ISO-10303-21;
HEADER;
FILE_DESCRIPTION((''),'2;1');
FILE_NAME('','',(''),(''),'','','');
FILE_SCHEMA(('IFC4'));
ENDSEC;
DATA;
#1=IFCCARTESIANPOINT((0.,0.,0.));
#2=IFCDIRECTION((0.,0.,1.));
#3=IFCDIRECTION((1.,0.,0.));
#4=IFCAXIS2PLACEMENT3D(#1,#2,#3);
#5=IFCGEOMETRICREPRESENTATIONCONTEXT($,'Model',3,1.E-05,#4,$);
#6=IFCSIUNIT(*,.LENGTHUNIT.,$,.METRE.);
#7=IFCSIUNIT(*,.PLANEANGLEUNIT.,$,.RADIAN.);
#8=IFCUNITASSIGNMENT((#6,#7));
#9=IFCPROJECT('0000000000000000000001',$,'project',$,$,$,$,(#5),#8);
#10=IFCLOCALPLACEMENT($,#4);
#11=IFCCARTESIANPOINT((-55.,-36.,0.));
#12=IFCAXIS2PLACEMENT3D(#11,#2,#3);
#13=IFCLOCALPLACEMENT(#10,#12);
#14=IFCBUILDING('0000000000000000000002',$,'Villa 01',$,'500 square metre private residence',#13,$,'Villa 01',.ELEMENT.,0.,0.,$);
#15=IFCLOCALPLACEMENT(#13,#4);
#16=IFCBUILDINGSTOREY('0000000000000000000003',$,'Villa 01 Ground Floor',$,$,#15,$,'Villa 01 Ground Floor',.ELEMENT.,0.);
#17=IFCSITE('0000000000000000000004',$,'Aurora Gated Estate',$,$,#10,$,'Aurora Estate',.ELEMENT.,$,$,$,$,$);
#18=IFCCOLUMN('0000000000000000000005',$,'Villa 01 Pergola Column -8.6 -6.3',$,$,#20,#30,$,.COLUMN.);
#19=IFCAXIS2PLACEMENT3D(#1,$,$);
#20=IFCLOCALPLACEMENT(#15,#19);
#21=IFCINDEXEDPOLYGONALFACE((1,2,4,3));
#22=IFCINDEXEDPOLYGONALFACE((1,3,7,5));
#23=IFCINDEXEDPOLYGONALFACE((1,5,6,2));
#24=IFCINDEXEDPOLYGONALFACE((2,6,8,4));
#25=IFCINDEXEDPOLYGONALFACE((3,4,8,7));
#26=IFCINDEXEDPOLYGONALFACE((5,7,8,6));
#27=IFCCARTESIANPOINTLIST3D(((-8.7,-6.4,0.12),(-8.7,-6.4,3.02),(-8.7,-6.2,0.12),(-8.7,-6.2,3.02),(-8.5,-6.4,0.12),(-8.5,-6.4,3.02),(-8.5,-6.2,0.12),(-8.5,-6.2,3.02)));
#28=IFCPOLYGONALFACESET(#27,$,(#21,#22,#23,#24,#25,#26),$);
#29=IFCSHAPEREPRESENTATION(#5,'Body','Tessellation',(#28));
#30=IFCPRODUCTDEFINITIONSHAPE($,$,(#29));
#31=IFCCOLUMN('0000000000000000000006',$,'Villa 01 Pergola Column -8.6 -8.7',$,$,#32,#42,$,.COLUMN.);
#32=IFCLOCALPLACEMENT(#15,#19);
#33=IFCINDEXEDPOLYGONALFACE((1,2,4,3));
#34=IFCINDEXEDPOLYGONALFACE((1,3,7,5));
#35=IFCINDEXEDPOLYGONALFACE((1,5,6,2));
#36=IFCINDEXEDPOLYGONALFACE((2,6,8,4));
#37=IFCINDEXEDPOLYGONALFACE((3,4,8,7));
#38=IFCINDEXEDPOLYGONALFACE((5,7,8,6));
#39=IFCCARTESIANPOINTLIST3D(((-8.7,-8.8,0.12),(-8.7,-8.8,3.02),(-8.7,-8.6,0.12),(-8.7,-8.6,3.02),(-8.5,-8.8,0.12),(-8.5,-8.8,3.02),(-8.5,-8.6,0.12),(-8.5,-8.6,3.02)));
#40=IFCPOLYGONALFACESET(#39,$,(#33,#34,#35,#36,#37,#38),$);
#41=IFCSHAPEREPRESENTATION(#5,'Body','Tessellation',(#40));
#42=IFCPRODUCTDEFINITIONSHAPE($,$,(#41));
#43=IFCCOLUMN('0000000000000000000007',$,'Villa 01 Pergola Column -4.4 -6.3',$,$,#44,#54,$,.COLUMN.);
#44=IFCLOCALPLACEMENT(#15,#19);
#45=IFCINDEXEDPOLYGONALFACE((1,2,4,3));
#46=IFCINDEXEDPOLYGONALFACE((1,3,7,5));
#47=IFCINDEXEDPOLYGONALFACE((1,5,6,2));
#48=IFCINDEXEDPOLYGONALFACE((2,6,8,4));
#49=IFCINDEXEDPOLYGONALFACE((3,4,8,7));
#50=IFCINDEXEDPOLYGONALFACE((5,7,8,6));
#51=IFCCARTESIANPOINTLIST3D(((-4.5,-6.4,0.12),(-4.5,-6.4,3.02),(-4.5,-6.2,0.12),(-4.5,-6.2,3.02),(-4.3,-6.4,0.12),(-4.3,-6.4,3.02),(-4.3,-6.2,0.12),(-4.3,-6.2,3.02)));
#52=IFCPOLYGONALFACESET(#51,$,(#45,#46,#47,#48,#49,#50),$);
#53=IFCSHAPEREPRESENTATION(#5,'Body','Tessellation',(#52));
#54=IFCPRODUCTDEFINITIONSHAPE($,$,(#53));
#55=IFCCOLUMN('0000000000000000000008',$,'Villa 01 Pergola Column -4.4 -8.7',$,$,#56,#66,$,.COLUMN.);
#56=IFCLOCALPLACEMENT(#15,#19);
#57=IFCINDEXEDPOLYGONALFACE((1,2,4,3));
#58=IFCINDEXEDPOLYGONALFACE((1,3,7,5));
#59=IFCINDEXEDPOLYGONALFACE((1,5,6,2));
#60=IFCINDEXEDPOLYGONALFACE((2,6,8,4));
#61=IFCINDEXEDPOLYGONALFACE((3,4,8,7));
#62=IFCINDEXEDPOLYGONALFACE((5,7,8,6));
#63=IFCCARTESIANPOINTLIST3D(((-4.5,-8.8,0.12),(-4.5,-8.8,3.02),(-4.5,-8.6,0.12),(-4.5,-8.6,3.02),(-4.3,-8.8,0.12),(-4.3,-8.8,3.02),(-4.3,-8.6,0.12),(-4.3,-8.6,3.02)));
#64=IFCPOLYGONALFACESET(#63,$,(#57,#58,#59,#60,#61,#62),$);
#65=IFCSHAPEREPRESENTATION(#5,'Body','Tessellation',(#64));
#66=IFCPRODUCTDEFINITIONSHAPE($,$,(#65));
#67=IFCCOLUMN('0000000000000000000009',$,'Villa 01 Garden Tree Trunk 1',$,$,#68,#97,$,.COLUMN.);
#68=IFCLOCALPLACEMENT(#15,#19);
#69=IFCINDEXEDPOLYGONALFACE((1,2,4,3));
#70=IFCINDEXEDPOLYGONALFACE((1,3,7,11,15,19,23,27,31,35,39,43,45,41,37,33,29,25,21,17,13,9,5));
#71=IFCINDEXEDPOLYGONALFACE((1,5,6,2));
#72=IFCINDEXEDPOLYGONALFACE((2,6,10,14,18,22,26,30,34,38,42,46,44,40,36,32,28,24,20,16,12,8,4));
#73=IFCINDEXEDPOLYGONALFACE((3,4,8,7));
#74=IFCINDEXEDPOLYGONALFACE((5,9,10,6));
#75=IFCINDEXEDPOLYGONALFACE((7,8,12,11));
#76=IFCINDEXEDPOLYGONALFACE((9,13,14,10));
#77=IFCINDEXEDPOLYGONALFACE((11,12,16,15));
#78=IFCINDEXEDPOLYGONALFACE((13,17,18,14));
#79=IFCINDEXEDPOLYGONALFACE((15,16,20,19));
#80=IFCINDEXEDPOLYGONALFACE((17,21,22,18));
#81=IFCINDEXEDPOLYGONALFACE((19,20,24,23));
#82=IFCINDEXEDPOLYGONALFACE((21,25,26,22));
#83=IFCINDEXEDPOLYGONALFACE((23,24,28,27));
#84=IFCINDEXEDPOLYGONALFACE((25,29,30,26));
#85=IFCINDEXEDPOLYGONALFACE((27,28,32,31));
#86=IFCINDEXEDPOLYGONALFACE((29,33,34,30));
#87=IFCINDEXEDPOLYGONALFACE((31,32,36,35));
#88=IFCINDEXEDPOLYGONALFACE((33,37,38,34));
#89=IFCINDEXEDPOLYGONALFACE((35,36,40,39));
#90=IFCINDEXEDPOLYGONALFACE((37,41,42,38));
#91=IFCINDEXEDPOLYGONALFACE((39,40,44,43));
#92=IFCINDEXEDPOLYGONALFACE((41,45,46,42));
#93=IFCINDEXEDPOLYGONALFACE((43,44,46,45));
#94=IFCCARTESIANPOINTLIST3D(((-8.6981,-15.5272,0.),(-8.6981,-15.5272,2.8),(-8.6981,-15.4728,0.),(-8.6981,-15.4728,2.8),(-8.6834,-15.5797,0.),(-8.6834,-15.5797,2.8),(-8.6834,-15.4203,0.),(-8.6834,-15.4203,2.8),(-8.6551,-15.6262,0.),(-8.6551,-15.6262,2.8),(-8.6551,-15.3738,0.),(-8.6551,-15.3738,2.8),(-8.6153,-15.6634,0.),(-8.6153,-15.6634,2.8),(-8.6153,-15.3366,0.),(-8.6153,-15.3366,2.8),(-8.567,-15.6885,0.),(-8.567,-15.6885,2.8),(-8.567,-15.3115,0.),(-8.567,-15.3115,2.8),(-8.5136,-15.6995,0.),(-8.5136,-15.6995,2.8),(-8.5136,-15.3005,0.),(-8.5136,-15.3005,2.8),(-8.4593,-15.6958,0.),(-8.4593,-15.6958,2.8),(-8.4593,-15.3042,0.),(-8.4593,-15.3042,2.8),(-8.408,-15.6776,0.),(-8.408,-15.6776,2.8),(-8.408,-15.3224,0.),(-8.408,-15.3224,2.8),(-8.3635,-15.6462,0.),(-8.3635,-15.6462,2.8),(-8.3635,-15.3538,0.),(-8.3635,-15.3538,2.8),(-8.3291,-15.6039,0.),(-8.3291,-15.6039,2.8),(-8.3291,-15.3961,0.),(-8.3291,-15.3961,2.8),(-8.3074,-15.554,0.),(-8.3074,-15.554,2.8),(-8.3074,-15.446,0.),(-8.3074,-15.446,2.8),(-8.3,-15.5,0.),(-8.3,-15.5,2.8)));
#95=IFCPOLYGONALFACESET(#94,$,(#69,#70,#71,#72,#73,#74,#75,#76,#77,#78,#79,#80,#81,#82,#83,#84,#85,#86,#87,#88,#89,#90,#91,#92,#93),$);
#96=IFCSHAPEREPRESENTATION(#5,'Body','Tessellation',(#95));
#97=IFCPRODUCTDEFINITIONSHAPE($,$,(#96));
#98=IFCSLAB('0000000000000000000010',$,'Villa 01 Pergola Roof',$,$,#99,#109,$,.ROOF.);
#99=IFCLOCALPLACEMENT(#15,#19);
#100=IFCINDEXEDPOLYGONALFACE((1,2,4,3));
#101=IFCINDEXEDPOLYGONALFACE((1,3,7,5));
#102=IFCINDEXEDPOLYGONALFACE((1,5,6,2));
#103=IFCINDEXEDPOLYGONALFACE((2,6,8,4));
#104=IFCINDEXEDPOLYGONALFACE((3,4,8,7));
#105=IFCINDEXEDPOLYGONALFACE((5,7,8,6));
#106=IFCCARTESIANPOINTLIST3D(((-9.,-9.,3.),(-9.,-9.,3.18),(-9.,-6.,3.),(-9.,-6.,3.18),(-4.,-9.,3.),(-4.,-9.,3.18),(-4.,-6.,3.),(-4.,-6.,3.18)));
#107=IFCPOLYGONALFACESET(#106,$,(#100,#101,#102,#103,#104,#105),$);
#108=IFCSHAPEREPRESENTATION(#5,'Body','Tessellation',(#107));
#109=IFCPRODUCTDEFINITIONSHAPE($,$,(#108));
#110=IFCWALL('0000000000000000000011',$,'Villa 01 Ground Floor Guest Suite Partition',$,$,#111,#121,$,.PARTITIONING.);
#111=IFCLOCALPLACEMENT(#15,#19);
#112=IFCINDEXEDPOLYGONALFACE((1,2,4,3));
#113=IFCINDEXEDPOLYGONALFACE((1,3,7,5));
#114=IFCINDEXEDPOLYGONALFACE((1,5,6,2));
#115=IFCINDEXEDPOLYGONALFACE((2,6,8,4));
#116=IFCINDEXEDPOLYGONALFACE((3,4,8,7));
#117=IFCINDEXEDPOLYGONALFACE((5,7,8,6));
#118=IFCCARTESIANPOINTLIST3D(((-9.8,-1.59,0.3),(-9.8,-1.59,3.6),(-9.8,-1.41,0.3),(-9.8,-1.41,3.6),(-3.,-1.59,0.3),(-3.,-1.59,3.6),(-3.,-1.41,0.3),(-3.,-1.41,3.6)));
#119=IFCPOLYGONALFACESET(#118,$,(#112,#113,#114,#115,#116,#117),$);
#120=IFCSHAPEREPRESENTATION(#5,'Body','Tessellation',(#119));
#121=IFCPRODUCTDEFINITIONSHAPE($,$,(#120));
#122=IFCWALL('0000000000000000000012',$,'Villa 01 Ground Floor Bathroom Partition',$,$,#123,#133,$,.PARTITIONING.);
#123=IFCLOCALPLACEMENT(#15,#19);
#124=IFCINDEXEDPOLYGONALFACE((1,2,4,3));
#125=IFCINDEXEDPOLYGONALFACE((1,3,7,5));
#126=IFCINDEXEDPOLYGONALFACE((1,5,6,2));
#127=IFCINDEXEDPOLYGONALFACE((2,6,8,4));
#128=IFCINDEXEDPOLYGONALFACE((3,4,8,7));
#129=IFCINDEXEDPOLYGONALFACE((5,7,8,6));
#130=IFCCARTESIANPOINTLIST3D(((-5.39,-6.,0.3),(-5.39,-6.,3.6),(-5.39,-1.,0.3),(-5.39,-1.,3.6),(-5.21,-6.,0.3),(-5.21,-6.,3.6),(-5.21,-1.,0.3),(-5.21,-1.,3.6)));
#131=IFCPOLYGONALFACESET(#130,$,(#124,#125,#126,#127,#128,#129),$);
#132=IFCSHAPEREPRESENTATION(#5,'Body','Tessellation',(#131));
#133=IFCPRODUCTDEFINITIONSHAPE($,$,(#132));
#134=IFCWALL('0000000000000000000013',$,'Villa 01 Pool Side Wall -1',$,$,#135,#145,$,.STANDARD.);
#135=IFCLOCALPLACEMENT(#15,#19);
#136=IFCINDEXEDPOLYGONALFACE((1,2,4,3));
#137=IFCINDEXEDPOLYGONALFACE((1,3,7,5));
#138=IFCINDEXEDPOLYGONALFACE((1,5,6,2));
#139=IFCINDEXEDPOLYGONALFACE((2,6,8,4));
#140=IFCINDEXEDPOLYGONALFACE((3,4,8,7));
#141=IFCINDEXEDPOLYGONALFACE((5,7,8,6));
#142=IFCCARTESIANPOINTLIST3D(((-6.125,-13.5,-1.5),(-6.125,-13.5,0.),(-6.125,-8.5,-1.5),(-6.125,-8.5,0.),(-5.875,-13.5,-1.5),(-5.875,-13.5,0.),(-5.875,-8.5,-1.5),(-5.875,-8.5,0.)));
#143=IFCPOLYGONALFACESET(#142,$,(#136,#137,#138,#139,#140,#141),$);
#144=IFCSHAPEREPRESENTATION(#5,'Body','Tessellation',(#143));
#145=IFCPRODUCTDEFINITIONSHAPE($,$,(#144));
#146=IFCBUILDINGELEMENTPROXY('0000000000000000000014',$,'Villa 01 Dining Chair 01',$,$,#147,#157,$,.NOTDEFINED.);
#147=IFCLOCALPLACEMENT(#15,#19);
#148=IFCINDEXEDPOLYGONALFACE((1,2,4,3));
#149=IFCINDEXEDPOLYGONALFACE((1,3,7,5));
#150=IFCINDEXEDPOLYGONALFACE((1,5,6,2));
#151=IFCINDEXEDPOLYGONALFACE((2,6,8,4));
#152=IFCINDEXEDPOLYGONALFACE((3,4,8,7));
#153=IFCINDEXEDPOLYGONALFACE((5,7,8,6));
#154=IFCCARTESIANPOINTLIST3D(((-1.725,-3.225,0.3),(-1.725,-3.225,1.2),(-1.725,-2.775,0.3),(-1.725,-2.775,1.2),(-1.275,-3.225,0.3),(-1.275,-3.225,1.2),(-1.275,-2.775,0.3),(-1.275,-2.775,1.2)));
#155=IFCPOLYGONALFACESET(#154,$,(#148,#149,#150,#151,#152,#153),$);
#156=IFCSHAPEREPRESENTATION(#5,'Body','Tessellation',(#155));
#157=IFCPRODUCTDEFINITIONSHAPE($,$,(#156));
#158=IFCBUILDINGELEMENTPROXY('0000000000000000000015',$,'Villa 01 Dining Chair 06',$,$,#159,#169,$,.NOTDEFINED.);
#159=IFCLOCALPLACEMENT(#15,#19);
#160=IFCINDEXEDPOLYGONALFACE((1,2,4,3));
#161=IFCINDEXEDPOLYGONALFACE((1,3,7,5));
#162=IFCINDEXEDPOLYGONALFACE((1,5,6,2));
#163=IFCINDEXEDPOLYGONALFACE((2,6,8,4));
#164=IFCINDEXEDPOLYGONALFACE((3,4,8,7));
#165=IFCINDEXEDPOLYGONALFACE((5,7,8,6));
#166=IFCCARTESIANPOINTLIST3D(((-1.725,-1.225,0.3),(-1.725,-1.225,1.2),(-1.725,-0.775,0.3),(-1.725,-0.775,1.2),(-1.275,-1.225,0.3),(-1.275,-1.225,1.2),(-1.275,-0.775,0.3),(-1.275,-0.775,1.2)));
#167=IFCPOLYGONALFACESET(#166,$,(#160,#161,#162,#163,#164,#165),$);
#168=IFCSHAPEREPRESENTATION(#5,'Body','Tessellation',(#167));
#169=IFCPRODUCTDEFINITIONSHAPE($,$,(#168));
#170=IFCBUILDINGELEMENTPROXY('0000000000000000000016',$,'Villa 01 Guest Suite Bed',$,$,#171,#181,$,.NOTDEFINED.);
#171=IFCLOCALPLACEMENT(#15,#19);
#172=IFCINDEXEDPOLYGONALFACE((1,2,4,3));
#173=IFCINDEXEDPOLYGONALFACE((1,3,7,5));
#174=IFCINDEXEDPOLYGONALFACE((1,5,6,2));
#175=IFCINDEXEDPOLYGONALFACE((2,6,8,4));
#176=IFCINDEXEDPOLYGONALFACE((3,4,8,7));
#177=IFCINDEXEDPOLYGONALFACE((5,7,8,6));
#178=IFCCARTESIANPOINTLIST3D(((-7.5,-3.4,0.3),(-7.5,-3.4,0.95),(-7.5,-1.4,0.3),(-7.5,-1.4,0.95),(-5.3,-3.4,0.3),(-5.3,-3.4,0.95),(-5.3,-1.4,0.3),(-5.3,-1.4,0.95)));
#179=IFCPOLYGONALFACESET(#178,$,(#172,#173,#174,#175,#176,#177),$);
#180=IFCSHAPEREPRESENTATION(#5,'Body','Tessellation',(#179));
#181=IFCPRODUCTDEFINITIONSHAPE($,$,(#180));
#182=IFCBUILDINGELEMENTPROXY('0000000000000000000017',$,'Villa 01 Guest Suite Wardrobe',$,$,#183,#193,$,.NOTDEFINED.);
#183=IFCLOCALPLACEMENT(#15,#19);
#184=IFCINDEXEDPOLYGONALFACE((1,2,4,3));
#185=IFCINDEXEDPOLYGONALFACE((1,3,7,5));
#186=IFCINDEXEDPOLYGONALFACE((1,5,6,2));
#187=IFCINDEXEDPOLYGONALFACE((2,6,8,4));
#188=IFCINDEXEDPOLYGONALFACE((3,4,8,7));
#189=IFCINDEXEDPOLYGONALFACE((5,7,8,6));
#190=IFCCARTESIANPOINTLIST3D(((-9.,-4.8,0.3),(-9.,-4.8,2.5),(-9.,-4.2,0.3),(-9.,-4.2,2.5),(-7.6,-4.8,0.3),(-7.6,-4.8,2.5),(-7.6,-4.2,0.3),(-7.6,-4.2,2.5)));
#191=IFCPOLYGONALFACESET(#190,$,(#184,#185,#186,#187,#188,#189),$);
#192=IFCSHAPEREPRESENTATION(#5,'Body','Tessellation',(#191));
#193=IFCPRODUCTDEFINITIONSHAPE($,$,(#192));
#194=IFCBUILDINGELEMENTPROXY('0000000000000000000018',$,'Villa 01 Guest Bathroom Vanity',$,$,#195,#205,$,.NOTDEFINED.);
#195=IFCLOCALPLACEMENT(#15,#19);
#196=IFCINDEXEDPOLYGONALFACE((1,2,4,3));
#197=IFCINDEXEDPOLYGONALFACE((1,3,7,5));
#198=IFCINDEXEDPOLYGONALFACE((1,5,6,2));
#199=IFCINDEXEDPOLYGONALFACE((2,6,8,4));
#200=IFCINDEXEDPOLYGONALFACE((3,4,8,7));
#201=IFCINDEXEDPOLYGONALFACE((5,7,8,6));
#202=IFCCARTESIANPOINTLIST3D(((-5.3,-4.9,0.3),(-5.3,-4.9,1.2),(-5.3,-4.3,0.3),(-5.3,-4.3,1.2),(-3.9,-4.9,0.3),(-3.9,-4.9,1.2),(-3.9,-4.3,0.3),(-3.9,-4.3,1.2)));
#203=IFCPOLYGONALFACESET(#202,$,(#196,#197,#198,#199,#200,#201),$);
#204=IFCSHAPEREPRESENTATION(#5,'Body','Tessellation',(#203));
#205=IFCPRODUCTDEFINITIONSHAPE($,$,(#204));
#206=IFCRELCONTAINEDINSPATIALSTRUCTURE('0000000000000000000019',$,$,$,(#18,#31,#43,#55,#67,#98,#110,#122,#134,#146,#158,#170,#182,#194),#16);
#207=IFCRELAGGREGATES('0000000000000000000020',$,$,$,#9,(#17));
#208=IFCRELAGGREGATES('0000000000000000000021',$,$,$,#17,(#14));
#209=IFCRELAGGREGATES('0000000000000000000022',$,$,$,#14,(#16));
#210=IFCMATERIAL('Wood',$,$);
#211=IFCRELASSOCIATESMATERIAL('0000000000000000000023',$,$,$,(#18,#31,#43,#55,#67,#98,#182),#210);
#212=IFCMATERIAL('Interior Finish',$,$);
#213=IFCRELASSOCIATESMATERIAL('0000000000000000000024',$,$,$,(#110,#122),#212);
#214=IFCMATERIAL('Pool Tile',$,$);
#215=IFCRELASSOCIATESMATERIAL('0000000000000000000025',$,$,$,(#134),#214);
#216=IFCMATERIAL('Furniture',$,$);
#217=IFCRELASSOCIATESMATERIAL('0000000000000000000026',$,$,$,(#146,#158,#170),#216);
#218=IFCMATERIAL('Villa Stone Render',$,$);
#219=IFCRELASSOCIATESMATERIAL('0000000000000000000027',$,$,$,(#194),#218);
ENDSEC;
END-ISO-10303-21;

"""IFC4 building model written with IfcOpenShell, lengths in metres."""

from ifc_helpers import new_model, si_unit, frame, origin_with_axes, origin_2d_with_axis, place, context, project, spatial, rectangle, circle, extrude, material, element, save


model = new_model("IFC4")

# Units and contexts
model_context = context("Model", 3, precision=1e-05, world=origin_with_axes())
ifc_project = project(units=[si_unit("LENGTHUNIT", "METRE"), si_unit("PLANEANGLEUNIT", "RADIAN")], contexts=[model_context])

# Site, building, storey
site_placement = place(None, origin_with_axes())
site = spatial("IfcSite", under=ifc_project, at=site_placement, Name="Aurora Gated Estate", LongName="Aurora Estate", CompositionType="ELEMENT")
building_placement = place(site_placement, frame((-55.0, -36.0, 0.0), z_axis=(0.0, 0.0, 1.0), x_axis=(1.0, 0.0, 0.0)))
building = spatial("IfcBuilding", under=site, at=building_placement, Name="Villa 01", ObjectType="500 square metre private residence", LongName="Villa 01", CompositionType="ELEMENT", ElevationOfRefHeight=0.0, ElevationOfTerrain=0.0)
storey_placement = place(building_placement, origin_with_axes())
storey = spatial("IfcBuildingStorey", under=building, at=storey_placement, Name="Villa 01 Ground Floor", LongName="Villa 01 Ground Floor", CompositionType="ELEMENT", Elevation=0.0)

# Columns
ifc_material_1 = material(Name="Wood")
for number, where, z_axis, x_axis, name in (
    (1, (-8.6, -6.3, 0.12), (0.0, 0.0, 1.0), (1.0, 0.0, 0.0), "Villa 01 Pergola Column -8.6 -6.3"),
    (2, (-8.6, -8.7, 0.12), (0.0, 0.0, 1.0), (1.0, 0.0, 0.0), "Villa 01 Pergola Column -8.6 -8.7"),
    (3, (-4.4, -6.3, 0.12), (0.0, 0.0, 1.0), (1.0, 0.0, 0.0), "Villa 01 Pergola Column -4.4 -6.3"),
    (4, (-4.4, -8.7, 0.12), (0.0, 0.0, 1.0), (1.0, 0.0, 0.0), "Villa 01 Pergola Column -4.4 -8.7"),
):
    element("IfcColumn", number, at=place(storey_placement, frame(where, z_axis=z_axis, x_axis=x_axis)), inside=storey, material=ifc_material_1, Name=name, PredefinedType="COLUMN", context=model_context, shape_type="SweptSolid", body=[
        extrude(rectangle(XDim=0.2, YDim=0.2, at=origin_2d_with_axis()), origin_with_axes(), (0.0, 0.0, 1.0), 2.9),
    ])
column_placement = place(storey_placement, frame((-8.5, -15.5, 0.0), z_axis=(0.0, 0.0, 1.0), x_axis=(1.0, 0.0, 0.0)))
element("IfcColumn", 5, at=column_placement, inside=storey, material=ifc_material_1, Name="Villa 01 Garden Tree Trunk 1", PredefinedType="COLUMN", context=model_context, shape_type="SweptSolid", body=[
    extrude(circle(Radius=0.2, at=origin_2d_with_axis()), origin_with_axes(), (0.0, 0.0, 1.0), 2.8),
])

# Slab
slab_placement = place(storey_placement, frame((-6.5, -7.5, 3.0), z_axis=(0.0, 0.0, 1.0), x_axis=(1.0, 0.0, 0.0)))
element("IfcSlab", 6, at=slab_placement, inside=storey, material=ifc_material_1, Name="Villa 01 Pergola Roof", PredefinedType="ROOF", context=model_context, shape_type="SweptSolid", body=[
    extrude(rectangle(XDim=5.0, YDim=3.0, at=origin_2d_with_axis()), origin_with_axes(), (0.0, 0.0, 1.0), 0.18),
])

# Walls
ifc_material_2 = material(Name="Interior Finish")
wall_1_placement = place(storey_placement, frame((-6.4, -1.5, 0.3), z_axis=(0.0, 0.0, 1.0), x_axis=(1.0, 0.0, 0.0)))
element("IfcWall", 7, at=wall_1_placement, inside=storey, material=ifc_material_2, Name="Villa 01 Ground Floor Guest Suite Partition", PredefinedType="PARTITIONING", context=model_context, shape_type="SweptSolid", body=[
    extrude(rectangle(XDim=6.8, YDim=0.18, at=origin_2d_with_axis()), origin_with_axes(), (0.0, 0.0, 1.0), 3.3),
])
wall_2_placement = place(storey_placement, frame((-5.3, -3.5, 0.3), z_axis=(0.0, 0.0, 1.0), x_axis=(1.0, 0.0, 0.0)))
element("IfcWall", 8, at=wall_2_placement, inside=storey, material=ifc_material_2, Name="Villa 01 Ground Floor Bathroom Partition", PredefinedType="PARTITIONING", context=model_context, shape_type="SweptSolid", body=[
    extrude(rectangle(XDim=0.18, YDim=5.0, at=origin_2d_with_axis()), origin_with_axes(), (0.0, 0.0, 1.0), 3.3),
])
ifc_material_3 = material(Name="Pool Tile")
wall_3_placement = place(storey_placement, frame((-6.0, -11.0, -1.5), z_axis=(0.0, 0.0, 1.0), x_axis=(1.0, 0.0, 0.0)))
element("IfcWall", 9, at=wall_3_placement, inside=storey, material=ifc_material_3, Name="Villa 01 Pool Side Wall -1", PredefinedType="STANDARD", context=model_context, shape_type="SweptSolid", body=[
    extrude(rectangle(XDim=0.25, YDim=5.0, at=origin_2d_with_axis()), origin_with_axes(), (0.0, 0.0, 1.0), 1.5),
])

# Building element proxies
ifc_material_4 = material(Name="Furniture")
for number, where, z_axis, x_axis, name in (
    (10, (-1.5, -3.0, 0.3), (0.0, 0.0, 1.0), (1.0, 0.0, 0.0), "Villa 01 Dining Chair 01"),
    (11, (-1.5, -1.0, 0.3), (0.0, 0.0, 1.0), (1.0, 0.0, 0.0), "Villa 01 Dining Chair 06"),
):
    element("IfcBuildingElementProxy", number, at=place(storey_placement, frame(where, z_axis=z_axis, x_axis=x_axis)), inside=storey, material=ifc_material_4, Name=name, PredefinedType="NOTDEFINED", context=model_context, shape_type="SweptSolid", body=[
        extrude(rectangle(XDim=0.45, YDim=0.45, at=origin_2d_with_axis()), origin_with_axes(), (0.0, 0.0, 1.0), 0.9),
    ])
proxy_1_placement = place(storey_placement, frame((-6.4, -2.4, 0.3), z_axis=(0.0, 0.0, 1.0), x_axis=(1.0, 0.0, 0.0)))
element("IfcBuildingElementProxy", 12, at=proxy_1_placement, inside=storey, material=ifc_material_4, Name="Villa 01 Guest Suite Bed", PredefinedType="NOTDEFINED", context=model_context, shape_type="SweptSolid", body=[
    extrude(rectangle(XDim=2.2, YDim=2.0, at=origin_2d_with_axis()), origin_with_axes(), (0.0, 0.0, 1.0), 0.65),
])
proxy_2_placement = place(storey_placement, frame((-8.3, -4.5, 0.3), z_axis=(0.0, 0.0, 1.0), x_axis=(1.0, 0.0, 0.0)))
element("IfcBuildingElementProxy", 13, at=proxy_2_placement, inside=storey, material=ifc_material_1, Name="Villa 01 Guest Suite Wardrobe", PredefinedType="NOTDEFINED", context=model_context, shape_type="SweptSolid", body=[
    extrude(rectangle(XDim=1.4, YDim=0.6, at=origin_2d_with_axis()), origin_with_axes(), (0.0, 0.0, 1.0), 2.2),
])
ifc_material_5 = material(Name="Villa Stone Render")
proxy_3_placement = place(storey_placement, frame((-4.6, -4.6, 0.3), z_axis=(0.0, 0.0, 1.0), x_axis=(1.0, 0.0, 0.0)))
element("IfcBuildingElementProxy", 14, at=proxy_3_placement, inside=storey, material=ifc_material_5, Name="Villa 01 Guest Bathroom Vanity", PredefinedType="NOTDEFINED", context=model_context, shape_type="SweptSolid", body=[
    extrude(rectangle(XDim=1.4, YDim=0.6, at=origin_2d_with_axis()), origin_with_axes(), (0.0, 0.0, 1.0), 0.9),
])

save(model, "model.ifc")
